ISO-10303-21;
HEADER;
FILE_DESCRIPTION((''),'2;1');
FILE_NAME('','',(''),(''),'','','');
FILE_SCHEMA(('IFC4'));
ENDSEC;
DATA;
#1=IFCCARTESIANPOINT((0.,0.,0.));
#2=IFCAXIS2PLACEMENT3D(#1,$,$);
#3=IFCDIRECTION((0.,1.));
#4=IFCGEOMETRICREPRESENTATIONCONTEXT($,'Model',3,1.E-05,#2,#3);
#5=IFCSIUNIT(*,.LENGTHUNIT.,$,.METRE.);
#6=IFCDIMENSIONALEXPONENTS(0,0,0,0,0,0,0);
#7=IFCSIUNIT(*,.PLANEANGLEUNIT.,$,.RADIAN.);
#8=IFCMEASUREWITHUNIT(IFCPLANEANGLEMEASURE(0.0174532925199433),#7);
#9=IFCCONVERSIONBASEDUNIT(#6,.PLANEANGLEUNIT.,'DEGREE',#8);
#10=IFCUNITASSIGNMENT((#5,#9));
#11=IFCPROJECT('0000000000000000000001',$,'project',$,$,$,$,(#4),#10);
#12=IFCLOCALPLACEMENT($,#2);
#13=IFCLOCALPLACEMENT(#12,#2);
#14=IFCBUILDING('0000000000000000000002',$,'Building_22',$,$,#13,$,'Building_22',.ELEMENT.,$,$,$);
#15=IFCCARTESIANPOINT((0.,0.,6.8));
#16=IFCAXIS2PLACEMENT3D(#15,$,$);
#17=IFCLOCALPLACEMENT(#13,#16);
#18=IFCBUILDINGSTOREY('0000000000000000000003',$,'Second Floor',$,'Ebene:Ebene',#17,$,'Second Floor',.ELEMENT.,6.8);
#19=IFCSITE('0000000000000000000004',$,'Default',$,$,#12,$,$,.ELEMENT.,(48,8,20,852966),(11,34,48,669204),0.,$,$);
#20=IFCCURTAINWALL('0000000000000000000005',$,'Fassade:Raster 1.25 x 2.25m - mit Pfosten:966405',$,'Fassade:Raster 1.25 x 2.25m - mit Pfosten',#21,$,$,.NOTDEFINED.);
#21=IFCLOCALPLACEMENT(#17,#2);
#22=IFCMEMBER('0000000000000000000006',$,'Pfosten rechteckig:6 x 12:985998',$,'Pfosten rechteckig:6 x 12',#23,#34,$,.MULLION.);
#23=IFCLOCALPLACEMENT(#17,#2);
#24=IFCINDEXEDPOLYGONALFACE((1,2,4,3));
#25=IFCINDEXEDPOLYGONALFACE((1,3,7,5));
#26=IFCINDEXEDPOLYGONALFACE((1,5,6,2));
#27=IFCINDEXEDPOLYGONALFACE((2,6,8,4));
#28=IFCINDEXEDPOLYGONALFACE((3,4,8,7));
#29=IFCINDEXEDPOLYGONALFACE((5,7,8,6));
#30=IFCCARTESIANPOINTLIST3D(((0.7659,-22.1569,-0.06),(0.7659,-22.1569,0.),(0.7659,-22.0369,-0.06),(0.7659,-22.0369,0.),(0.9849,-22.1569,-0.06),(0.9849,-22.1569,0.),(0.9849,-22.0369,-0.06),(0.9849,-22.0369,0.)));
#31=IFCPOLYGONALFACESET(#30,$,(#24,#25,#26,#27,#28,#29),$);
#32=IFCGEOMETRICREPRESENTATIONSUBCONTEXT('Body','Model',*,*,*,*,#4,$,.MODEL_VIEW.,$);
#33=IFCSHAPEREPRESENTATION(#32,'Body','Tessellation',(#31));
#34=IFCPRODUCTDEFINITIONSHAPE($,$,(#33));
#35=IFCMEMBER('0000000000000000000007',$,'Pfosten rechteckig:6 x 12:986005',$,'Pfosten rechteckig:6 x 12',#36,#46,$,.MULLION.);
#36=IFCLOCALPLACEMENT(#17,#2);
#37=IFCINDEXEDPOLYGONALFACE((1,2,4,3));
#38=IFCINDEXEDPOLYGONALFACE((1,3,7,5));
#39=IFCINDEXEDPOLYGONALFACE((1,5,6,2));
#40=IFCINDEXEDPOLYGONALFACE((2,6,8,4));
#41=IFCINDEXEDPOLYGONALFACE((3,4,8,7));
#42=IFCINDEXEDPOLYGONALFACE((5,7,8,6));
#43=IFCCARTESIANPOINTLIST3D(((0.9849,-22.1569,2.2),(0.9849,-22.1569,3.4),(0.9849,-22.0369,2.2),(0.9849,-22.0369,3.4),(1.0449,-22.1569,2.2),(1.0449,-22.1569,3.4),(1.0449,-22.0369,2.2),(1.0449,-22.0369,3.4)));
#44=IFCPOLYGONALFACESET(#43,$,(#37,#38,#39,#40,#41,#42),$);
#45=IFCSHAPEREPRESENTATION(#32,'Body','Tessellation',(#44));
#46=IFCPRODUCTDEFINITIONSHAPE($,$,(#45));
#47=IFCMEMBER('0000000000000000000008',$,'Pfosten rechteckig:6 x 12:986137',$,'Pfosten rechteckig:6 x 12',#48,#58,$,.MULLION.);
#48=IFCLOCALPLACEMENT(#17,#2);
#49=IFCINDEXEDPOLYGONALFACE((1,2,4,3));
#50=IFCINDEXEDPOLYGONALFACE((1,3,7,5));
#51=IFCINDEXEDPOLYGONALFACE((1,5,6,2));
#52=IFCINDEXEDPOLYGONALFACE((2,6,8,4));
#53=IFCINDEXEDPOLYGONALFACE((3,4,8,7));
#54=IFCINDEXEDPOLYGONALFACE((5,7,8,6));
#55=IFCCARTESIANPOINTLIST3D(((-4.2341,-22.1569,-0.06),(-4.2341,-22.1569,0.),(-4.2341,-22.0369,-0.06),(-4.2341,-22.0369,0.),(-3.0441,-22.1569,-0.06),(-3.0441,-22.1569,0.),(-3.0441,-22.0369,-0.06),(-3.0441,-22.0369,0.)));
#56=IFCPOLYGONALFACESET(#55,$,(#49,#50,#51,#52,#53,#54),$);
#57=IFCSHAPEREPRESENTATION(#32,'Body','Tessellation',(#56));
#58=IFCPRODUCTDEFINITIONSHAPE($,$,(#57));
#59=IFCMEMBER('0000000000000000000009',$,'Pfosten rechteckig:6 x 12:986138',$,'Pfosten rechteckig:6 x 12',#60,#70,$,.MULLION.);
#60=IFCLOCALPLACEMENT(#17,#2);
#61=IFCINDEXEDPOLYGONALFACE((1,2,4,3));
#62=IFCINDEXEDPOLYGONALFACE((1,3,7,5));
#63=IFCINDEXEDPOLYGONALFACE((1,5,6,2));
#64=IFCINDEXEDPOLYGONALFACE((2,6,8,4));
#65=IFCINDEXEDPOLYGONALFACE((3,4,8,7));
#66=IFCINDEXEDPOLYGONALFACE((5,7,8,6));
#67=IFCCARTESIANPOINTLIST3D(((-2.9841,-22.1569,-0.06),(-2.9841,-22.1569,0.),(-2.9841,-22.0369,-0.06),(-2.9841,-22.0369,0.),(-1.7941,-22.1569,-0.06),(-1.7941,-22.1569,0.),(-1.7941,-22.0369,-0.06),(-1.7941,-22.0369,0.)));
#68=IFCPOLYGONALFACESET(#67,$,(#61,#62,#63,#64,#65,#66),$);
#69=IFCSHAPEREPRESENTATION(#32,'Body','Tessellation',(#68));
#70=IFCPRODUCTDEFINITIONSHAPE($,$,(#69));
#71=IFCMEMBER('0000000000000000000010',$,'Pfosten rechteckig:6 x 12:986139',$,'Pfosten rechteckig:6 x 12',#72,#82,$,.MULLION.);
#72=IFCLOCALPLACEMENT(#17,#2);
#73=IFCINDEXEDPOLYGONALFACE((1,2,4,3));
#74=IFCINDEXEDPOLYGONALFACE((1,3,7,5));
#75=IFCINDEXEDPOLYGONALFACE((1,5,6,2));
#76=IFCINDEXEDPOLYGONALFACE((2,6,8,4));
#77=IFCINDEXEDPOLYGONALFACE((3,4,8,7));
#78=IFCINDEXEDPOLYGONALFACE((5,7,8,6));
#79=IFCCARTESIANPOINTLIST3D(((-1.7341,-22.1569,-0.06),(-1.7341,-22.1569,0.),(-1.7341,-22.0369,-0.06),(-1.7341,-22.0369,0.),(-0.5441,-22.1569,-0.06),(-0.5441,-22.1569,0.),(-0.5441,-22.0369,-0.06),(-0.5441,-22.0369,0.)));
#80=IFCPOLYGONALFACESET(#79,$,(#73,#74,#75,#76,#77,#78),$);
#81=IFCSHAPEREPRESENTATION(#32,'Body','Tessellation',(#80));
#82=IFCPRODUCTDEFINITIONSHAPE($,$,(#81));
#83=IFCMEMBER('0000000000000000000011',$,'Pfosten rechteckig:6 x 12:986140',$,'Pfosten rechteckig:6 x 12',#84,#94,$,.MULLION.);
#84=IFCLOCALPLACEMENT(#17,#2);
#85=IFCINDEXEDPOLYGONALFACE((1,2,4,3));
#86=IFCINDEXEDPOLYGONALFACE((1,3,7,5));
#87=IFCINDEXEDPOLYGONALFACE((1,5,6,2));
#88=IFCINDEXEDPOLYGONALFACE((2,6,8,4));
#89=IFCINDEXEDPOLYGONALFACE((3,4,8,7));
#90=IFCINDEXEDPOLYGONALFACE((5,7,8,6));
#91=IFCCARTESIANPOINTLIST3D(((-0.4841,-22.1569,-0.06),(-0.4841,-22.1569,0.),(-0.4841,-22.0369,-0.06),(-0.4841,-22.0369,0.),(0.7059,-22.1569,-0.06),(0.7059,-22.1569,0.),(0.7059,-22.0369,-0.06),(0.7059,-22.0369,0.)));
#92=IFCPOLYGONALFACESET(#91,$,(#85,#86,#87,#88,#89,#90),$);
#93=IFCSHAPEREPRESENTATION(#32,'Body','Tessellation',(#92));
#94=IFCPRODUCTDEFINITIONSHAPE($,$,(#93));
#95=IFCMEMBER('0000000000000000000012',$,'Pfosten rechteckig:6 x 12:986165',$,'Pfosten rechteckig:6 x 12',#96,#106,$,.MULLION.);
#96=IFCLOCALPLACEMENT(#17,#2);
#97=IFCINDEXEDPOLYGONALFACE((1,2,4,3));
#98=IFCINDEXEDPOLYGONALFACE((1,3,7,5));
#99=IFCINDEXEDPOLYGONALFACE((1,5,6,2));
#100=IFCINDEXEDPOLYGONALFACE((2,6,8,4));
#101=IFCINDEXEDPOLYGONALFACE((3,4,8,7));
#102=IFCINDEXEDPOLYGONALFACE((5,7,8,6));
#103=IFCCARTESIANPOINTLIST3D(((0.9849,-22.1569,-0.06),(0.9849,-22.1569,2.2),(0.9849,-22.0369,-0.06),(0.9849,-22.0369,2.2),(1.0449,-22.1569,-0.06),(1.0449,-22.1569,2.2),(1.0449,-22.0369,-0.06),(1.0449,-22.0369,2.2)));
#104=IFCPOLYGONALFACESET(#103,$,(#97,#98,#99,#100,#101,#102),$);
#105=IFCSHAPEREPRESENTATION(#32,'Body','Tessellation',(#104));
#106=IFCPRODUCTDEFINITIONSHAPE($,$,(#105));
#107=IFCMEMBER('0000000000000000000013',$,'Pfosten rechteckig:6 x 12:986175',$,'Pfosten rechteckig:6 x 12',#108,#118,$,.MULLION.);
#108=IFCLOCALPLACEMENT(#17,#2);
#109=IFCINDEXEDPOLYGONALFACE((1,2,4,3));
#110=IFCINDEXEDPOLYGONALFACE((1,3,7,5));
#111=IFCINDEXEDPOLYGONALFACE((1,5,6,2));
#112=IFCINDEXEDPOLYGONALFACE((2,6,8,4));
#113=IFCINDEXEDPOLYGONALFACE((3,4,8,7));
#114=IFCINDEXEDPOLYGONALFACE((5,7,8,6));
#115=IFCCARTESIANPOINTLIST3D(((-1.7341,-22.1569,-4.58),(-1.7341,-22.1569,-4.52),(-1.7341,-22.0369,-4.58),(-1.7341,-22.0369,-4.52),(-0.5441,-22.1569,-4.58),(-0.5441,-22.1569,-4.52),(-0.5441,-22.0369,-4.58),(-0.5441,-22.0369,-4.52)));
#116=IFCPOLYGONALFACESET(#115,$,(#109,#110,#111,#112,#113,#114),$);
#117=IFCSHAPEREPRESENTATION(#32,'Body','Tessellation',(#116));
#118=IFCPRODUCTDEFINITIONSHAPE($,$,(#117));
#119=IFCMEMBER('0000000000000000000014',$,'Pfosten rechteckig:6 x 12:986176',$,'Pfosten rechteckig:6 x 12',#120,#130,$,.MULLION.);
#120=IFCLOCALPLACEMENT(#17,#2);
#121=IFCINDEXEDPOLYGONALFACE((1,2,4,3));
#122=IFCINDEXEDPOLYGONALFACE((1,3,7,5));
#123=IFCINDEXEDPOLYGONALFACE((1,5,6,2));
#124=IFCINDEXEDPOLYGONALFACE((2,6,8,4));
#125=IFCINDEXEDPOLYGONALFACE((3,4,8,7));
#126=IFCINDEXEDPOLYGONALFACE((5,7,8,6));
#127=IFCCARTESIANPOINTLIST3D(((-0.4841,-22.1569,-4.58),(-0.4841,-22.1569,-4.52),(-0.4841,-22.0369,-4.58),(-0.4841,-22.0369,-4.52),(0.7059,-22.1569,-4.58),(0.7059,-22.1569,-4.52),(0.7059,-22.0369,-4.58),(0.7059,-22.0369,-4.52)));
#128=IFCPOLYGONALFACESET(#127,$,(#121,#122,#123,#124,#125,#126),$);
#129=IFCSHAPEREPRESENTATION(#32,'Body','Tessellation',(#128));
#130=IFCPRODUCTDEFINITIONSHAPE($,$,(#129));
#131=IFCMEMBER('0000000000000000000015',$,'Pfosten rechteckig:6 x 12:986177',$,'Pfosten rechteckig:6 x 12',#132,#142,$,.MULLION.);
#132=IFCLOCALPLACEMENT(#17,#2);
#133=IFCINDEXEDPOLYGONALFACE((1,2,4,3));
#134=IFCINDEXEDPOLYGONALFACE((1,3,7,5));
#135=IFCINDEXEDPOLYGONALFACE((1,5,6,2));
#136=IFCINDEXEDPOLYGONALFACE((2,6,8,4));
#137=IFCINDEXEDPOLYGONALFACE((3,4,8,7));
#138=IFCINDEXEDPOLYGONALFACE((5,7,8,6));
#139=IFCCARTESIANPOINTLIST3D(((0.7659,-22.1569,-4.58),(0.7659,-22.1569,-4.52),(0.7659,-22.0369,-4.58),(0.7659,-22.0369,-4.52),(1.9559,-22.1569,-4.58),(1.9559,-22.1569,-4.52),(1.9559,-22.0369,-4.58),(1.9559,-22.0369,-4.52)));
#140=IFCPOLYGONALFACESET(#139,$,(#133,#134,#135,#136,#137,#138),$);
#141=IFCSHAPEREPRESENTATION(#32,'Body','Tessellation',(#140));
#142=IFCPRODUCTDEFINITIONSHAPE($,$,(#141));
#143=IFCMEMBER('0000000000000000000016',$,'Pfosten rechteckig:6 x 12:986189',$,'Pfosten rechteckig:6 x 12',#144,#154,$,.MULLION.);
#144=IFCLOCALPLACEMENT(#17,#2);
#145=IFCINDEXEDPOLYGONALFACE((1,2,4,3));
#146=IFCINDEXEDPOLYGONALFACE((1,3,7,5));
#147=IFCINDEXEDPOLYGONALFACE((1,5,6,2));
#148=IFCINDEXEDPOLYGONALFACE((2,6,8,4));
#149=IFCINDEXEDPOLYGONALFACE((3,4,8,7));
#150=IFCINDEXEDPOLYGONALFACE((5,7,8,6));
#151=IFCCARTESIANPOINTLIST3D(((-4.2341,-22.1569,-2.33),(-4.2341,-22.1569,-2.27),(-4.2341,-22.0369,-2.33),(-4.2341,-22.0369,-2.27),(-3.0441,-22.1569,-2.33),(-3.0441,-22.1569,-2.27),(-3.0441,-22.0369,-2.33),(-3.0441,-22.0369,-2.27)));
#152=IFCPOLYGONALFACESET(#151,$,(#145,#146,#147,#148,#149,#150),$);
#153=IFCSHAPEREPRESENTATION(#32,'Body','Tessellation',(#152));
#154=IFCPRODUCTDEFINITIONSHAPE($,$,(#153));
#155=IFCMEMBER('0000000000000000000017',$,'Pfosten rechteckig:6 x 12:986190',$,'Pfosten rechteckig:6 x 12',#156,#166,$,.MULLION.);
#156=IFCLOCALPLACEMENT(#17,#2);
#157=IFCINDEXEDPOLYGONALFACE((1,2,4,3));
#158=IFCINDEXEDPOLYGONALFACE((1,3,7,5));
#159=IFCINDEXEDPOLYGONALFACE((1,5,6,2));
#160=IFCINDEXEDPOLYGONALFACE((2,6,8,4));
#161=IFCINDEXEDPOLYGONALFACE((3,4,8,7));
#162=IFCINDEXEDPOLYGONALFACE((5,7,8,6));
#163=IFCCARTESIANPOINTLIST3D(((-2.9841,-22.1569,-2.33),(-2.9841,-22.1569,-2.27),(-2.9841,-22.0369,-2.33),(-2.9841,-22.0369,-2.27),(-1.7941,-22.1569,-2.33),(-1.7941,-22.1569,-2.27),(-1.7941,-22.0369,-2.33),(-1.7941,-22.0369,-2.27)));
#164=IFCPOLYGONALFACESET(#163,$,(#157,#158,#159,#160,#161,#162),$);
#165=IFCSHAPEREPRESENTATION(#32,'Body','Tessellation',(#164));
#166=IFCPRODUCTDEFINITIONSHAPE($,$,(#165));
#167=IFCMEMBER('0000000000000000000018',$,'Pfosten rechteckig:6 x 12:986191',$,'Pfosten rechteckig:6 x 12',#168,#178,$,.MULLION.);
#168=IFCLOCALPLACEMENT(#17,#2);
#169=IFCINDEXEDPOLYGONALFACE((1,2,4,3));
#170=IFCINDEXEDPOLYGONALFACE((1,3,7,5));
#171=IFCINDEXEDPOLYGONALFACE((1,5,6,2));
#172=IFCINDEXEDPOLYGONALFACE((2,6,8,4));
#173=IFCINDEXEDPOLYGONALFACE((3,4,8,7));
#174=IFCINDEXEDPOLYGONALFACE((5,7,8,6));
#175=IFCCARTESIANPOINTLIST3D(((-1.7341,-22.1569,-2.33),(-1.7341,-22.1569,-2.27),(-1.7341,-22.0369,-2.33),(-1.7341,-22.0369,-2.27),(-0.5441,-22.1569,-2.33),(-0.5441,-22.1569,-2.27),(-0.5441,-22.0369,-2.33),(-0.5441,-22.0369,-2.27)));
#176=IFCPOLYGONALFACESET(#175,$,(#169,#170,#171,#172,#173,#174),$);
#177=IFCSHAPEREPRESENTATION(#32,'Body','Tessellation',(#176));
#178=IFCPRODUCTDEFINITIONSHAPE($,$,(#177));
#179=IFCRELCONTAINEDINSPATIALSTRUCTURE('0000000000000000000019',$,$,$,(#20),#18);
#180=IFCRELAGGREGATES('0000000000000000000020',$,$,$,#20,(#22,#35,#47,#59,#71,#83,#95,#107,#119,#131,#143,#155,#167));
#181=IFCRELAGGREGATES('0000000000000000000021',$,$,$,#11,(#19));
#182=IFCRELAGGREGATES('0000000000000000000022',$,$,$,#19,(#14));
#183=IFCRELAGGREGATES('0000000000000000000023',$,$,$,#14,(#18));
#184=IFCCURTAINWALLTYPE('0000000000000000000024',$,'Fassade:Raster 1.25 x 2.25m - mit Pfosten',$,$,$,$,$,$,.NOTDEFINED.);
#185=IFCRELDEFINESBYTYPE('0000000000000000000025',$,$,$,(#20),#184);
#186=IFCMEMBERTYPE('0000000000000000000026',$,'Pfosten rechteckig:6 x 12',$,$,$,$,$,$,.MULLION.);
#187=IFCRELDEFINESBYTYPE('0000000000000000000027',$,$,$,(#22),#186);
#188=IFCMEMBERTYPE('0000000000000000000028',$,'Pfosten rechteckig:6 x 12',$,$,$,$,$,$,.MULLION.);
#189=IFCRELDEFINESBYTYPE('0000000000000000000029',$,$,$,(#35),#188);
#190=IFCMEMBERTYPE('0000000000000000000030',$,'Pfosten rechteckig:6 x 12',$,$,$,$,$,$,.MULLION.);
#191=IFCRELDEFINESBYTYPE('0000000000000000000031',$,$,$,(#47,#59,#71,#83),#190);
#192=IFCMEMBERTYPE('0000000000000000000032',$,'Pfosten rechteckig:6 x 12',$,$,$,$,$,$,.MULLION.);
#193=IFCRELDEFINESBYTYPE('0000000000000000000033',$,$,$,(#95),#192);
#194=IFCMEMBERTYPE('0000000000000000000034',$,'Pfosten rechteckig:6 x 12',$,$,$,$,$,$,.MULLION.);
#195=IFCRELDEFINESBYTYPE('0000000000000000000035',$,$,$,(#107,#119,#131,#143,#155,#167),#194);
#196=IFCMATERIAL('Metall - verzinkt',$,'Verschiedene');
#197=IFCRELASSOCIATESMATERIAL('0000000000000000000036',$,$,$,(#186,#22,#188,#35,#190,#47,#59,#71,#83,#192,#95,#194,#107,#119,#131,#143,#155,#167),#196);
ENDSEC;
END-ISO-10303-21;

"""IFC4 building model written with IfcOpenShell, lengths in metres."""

from ifc_helpers import new_model, entity, si_unit, converted_unit, direction, frame, origin, place, context, subcontext, project, spatial, indexed_curve, outline, extrude, source, transform, mapped, material, type_object, type_shapes, element, aggregate, save


model = new_model("IFC4")

# Units and contexts
model_context = context("Model", 3, precision=1e-05, world=origin(), true_north=direction((0.0, 1.0)))
body_context = subcontext(model_context, "Body", "Model", "MODEL_VIEW")
ifc_project = project(units=[si_unit("LENGTHUNIT", "METRE"), converted_unit("PLANEANGLEUNIT", "DEGREE", entity("IfcPlaneAngleMeasure", 0.0174532925199433), si_unit("PLANEANGLEUNIT", "RADIAN"), dimensions=[0, 0, 0, 0, 0, 0, 0])], contexts=[model_context])

# Site, building, storey
site_placement = place(None, origin())
site = spatial("IfcSite", under=ifc_project, at=site_placement, Name="Default", CompositionType="ELEMENT", RefLatitude=(48, 8, 20, 852966), RefLongitude=(11, 34, 48, 669204), RefElevation=0.0)
building_placement = place(site_placement, origin())
building = spatial("IfcBuilding", under=site, at=building_placement, Name="Building_22", LongName="Building_22", CompositionType="ELEMENT")
storey_placement = place(building_placement, frame((0.0, 0.0, 6.8)))
storey = spatial("IfcBuildingStorey", under=building, at=storey_placement, Name="Second Floor", ObjectType="Ebene:Ebene", LongName="Second Floor", CompositionType="ELEMENT", Elevation=6.8)

# Curtain wall, members
curtain_wall_type = type_object("IfcCurtainWallType", Name="Fassade:Raster 1.25 x 2.25m - mit Pfosten", PredefinedType="NOTDEFINED")
curtain_wall_placement = place(storey_placement, frame((0.0, 0.0, -6.8)))
curtain_wall = element("IfcCurtainWall", 1, at=curtain_wall_placement, inside=storey, type_object=curtain_wall_type, Name="Fassade:Raster 1.25 x 2.25m - mit Pfosten:966405", ObjectType="Fassade:Raster 1.25 x 2.25m - mit Pfosten", PredefinedType="NOTDEFINED")
ifc_material_1 = material(Name="Metall - verzinkt", Category="Verschiedene")
member_type_1 = type_object("IfcMemberType", Name="Pfosten rechteckig:6 x 12", PredefinedType="MULLION", material=ifc_material_1)
shared_shape_1 = source(origin(), body_context, "Body", "SweptSolid", [
    extrude(outline(indexed_curve([(-0.03, -0.06), (0.03, -0.06), (0.03, 0.06), (-0.03, 0.06), (-0.03, -0.06)], self_intersect=False)), frame((-0.03, 0.0, -0.219), z_axis=(0.0, 0.0, 1.0), x_axis=(-1.0, 0.0, 0.0)), (0.0, 0.0, 1.0), 0.219),
])
type_shapes(member_type_1, [shared_shape_1])
member_1_placement = place(curtain_wall_placement, frame((0.9849, -22.0969, 6.8), z_axis=(1.0, 0.0, 0.0), x_axis=(0.0, 0.0, 1.0)))
member_1 = element("IfcMember", 2, at=member_1_placement, type_object=member_type_1, material=ifc_material_1, Name="Pfosten rechteckig:6 x 12:985998", ObjectType="Pfosten rechteckig:6 x 12", PredefinedType="MULLION", context=body_context, shape_type="MappedRepresentation", body=[
    mapped(shared_shape_1, transform((0.0, 0.0, 0.0), scale=1.0)),
])
member_type_2 = type_object("IfcMemberType", Name="Pfosten rechteckig:6 x 12", PredefinedType="MULLION", material=ifc_material_1)
shared_shape_2 = source(origin(), body_context, "Body", "SweptSolid", [
    extrude(outline(indexed_curve([(-0.03, -0.06), (0.03, -0.06), (0.03, 0.06), (-0.03, 0.06), (-0.03, -0.06)], self_intersect=False)), frame((-0.03, 0.0, -1.2), z_axis=(0.0, 0.0, 1.0), x_axis=(-1.0, 0.0, 0.0)), (0.0, 0.0, 1.0), 1.2),
])
type_shapes(member_type_2, [shared_shape_2])
member_2_placement = place(curtain_wall_placement, frame((0.9849, -22.0969, 10.2), z_axis=(0.0, 0.0, 1.0), x_axis=(-1.0, 0.0, 0.0)))
member_2 = element("IfcMember", 3, at=member_2_placement, type_object=member_type_2, material=ifc_material_1, Name="Pfosten rechteckig:6 x 12:986005", ObjectType="Pfosten rechteckig:6 x 12", PredefinedType="MULLION", context=body_context, shape_type="MappedRepresentation", body=[
    mapped(shared_shape_2, transform((0.0, 0.0, 0.0), scale=1.0)),
])
member_type_3 = type_object("IfcMemberType", Name="Pfosten rechteckig:6 x 12", PredefinedType="MULLION", material=ifc_material_1)
shared_shape_3 = source(origin(), body_context, "Body", "SweptSolid", [
    extrude(outline(indexed_curve([(-0.03, -0.06), (0.03, -0.06), (0.03, 0.06), (-0.03, 0.06), (-0.03, -0.06)], self_intersect=False)), frame((-0.03, 0.0, -1.19), z_axis=(0.0, 0.0, 1.0), x_axis=(-1.0, 0.0, 0.0)), (0.0, 0.0, 1.0), 1.19),
])
type_shapes(member_type_3, [shared_shape_3])
member_3_placement = place(curtain_wall_placement, frame((-3.0441, -22.0969, 6.8), z_axis=(1.0, 0.0, 0.0), x_axis=(0.0, 0.0, 1.0)))
member_3 = element("IfcMember", 4, at=member_3_placement, type_object=member_type_3, material=ifc_material_1, Name="Pfosten rechteckig:6 x 12:986137", ObjectType="Pfosten rechteckig:6 x 12", PredefinedType="MULLION", context=body_context, shape_type="MappedRepresentation", body=[
    mapped(shared_shape_3, transform((0.0, 0.0, 0.0), scale=1.0)),
])
member_4_placement = place(curtain_wall_placement, frame((-1.7941, -22.0969, 6.8), z_axis=(1.0, 0.0, 0.0), x_axis=(0.0, 0.0, 1.0)))
member_4 = element("IfcMember", 5, at=member_4_placement, type_object=member_type_3, material=ifc_material_1, Name="Pfosten rechteckig:6 x 12:986138", ObjectType="Pfosten rechteckig:6 x 12", PredefinedType="MULLION", context=body_context, shape_type="MappedRepresentation", body=[
    mapped(shared_shape_3, transform((0.0, 0.0, 0.0), scale=1.0)),
])
member_5_placement = place(curtain_wall_placement, frame((-0.5441, -22.0969, 6.8), z_axis=(1.0, 0.0, 0.0), x_axis=(0.0, 0.0, 1.0)))
member_5 = element("IfcMember", 6, at=member_5_placement, type_object=member_type_3, material=ifc_material_1, Name="Pfosten rechteckig:6 x 12:986139", ObjectType="Pfosten rechteckig:6 x 12", PredefinedType="MULLION", context=body_context, shape_type="MappedRepresentation", body=[
    mapped(shared_shape_3, transform((0.0, 0.0, 0.0), scale=1.0)),
])
member_6_placement = place(curtain_wall_placement, frame((0.7059, -22.0969, 6.8), z_axis=(1.0, 0.0, 0.0), x_axis=(0.0, 0.0, 1.0)))
member_6 = element("IfcMember", 7, at=member_6_placement, type_object=member_type_3, material=ifc_material_1, Name="Pfosten rechteckig:6 x 12:986140", ObjectType="Pfosten rechteckig:6 x 12", PredefinedType="MULLION", context=body_context, shape_type="MappedRepresentation", body=[
    mapped(shared_shape_3, transform((0.0, 0.0, 0.0), scale=1.0)),
])
member_type_4 = type_object("IfcMemberType", Name="Pfosten rechteckig:6 x 12", PredefinedType="MULLION", material=ifc_material_1)
shared_shape_4 = source(origin(), body_context, "Body", "SweptSolid", [
    extrude(outline(indexed_curve([(-0.03, -0.06), (0.03, -0.06), (0.03, 0.06), (-0.03, 0.06), (-0.03, -0.06)], self_intersect=False)), frame((-0.03, 0.0, -2.26), z_axis=(0.0, 0.0, 1.0), x_axis=(-1.0, 0.0, 0.0)), (0.0, 0.0, 1.0), 2.26),
])
type_shapes(member_type_4, [shared_shape_4])
member_7_placement = place(curtain_wall_placement, frame((0.9849, -22.0969, 9.0), z_axis=(0.0, 0.0, 1.0), x_axis=(-1.0, 0.0, 0.0)))
member_7 = element("IfcMember", 8, at=member_7_placement, type_object=member_type_4, material=ifc_material_1, Name="Pfosten rechteckig:6 x 12:986165", ObjectType="Pfosten rechteckig:6 x 12", PredefinedType="MULLION", context=body_context, shape_type="MappedRepresentation", body=[
    mapped(shared_shape_4, transform((0.0, 0.0, 0.0), scale=1.0)),
])
member_type_5 = type_object("IfcMemberType", Name="Pfosten rechteckig:6 x 12", PredefinedType="MULLION", material=ifc_material_1)
shared_shape_5 = source(origin(), body_context, "Body", "SweptSolid", [
    extrude(outline(indexed_curve([(-0.03, -0.06), (0.03, -0.06), (0.03, 0.06), (-0.03, 0.06), (-0.03, -0.06)], self_intersect=False)), frame((0.0, 0.0, -1.19), z_axis=(0.0, 0.0, 1.0), x_axis=(-1.0, 0.0, 0.0)), (0.0, 0.0, 1.0), 1.19),
])
type_shapes(member_type_5, [shared_shape_5])
member_8_placement = place(curtain_wall_placement, frame((-0.5441, -22.0969, 2.25), z_axis=(1.0, 0.0, 0.0), x_axis=(0.0, 0.0, 1.0)))
member_8 = element("IfcMember", 9, at=member_8_placement, type_object=member_type_5, material=ifc_material_1, Name="Pfosten rechteckig:6 x 12:986175", ObjectType="Pfosten rechteckig:6 x 12", PredefinedType="MULLION", context=body_context, shape_type="MappedRepresentation", body=[
    mapped(shared_shape_5, transform((0.0, 0.0, 0.0), scale=1.0)),
])
member_9_placement = place(curtain_wall_placement, frame((0.7059, -22.0969, 2.25), z_axis=(1.0, 0.0, 0.0), x_axis=(0.0, 0.0, 1.0)))
member_9 = element("IfcMember", 10, at=member_9_placement, type_object=member_type_5, material=ifc_material_1, Name="Pfosten rechteckig:6 x 12:986176", ObjectType="Pfosten rechteckig:6 x 12", PredefinedType="MULLION", context=body_context, shape_type="MappedRepresentation", body=[
    mapped(shared_shape_5, transform((0.0, 0.0, 0.0), scale=1.0)),
])
member_10_placement = place(curtain_wall_placement, frame((1.9559, -22.0969, 2.25), z_axis=(1.0, 0.0, 0.0), x_axis=(0.0, 0.0, 1.0)))
member_10 = element("IfcMember", 11, at=member_10_placement, type_object=member_type_5, material=ifc_material_1, Name="Pfosten rechteckig:6 x 12:986177", ObjectType="Pfosten rechteckig:6 x 12", PredefinedType="MULLION", context=body_context, shape_type="MappedRepresentation", body=[
    mapped(shared_shape_5, transform((0.0, 0.0, 0.0), scale=1.0)),
])
member_11_placement = place(curtain_wall_placement, frame((-3.0441, -22.0969, 4.5), z_axis=(1.0, 0.0, 0.0), x_axis=(0.0, 0.0, 1.0)))
member_11 = element("IfcMember", 12, at=member_11_placement, type_object=member_type_5, material=ifc_material_1, Name="Pfosten rechteckig:6 x 12:986189", ObjectType="Pfosten rechteckig:6 x 12", PredefinedType="MULLION", context=body_context, shape_type="MappedRepresentation", body=[
    mapped(shared_shape_5, transform((0.0, 0.0, 0.0), scale=1.0)),
])
member_12_placement = place(curtain_wall_placement, frame((-1.7941, -22.0969, 4.5), z_axis=(1.0, 0.0, 0.0), x_axis=(0.0, 0.0, 1.0)))
member_12 = element("IfcMember", 13, at=member_12_placement, type_object=member_type_5, material=ifc_material_1, Name="Pfosten rechteckig:6 x 12:986190", ObjectType="Pfosten rechteckig:6 x 12", PredefinedType="MULLION", context=body_context, shape_type="MappedRepresentation", body=[
    mapped(shared_shape_5, transform((0.0, 0.0, 0.0), scale=1.0)),
])
member_13_placement = place(curtain_wall_placement, frame((-0.5441, -22.0969, 4.5), z_axis=(1.0, 0.0, 0.0), x_axis=(0.0, 0.0, 1.0)))
member_13 = element("IfcMember", 14, at=member_13_placement, type_object=member_type_5, material=ifc_material_1, Name="Pfosten rechteckig:6 x 12:986191", ObjectType="Pfosten rechteckig:6 x 12", PredefinedType="MULLION", context=body_context, shape_type="MappedRepresentation", body=[
    mapped(shared_shape_5, transform((0.0, 0.0, 0.0), scale=1.0)),
])
aggregate(curtain_wall, [member_1, member_2, member_3, member_4, member_5, member_6, member_7, member_8, member_9, member_10, member_11, member_12, member_13])

save(model, "model.ifc")
